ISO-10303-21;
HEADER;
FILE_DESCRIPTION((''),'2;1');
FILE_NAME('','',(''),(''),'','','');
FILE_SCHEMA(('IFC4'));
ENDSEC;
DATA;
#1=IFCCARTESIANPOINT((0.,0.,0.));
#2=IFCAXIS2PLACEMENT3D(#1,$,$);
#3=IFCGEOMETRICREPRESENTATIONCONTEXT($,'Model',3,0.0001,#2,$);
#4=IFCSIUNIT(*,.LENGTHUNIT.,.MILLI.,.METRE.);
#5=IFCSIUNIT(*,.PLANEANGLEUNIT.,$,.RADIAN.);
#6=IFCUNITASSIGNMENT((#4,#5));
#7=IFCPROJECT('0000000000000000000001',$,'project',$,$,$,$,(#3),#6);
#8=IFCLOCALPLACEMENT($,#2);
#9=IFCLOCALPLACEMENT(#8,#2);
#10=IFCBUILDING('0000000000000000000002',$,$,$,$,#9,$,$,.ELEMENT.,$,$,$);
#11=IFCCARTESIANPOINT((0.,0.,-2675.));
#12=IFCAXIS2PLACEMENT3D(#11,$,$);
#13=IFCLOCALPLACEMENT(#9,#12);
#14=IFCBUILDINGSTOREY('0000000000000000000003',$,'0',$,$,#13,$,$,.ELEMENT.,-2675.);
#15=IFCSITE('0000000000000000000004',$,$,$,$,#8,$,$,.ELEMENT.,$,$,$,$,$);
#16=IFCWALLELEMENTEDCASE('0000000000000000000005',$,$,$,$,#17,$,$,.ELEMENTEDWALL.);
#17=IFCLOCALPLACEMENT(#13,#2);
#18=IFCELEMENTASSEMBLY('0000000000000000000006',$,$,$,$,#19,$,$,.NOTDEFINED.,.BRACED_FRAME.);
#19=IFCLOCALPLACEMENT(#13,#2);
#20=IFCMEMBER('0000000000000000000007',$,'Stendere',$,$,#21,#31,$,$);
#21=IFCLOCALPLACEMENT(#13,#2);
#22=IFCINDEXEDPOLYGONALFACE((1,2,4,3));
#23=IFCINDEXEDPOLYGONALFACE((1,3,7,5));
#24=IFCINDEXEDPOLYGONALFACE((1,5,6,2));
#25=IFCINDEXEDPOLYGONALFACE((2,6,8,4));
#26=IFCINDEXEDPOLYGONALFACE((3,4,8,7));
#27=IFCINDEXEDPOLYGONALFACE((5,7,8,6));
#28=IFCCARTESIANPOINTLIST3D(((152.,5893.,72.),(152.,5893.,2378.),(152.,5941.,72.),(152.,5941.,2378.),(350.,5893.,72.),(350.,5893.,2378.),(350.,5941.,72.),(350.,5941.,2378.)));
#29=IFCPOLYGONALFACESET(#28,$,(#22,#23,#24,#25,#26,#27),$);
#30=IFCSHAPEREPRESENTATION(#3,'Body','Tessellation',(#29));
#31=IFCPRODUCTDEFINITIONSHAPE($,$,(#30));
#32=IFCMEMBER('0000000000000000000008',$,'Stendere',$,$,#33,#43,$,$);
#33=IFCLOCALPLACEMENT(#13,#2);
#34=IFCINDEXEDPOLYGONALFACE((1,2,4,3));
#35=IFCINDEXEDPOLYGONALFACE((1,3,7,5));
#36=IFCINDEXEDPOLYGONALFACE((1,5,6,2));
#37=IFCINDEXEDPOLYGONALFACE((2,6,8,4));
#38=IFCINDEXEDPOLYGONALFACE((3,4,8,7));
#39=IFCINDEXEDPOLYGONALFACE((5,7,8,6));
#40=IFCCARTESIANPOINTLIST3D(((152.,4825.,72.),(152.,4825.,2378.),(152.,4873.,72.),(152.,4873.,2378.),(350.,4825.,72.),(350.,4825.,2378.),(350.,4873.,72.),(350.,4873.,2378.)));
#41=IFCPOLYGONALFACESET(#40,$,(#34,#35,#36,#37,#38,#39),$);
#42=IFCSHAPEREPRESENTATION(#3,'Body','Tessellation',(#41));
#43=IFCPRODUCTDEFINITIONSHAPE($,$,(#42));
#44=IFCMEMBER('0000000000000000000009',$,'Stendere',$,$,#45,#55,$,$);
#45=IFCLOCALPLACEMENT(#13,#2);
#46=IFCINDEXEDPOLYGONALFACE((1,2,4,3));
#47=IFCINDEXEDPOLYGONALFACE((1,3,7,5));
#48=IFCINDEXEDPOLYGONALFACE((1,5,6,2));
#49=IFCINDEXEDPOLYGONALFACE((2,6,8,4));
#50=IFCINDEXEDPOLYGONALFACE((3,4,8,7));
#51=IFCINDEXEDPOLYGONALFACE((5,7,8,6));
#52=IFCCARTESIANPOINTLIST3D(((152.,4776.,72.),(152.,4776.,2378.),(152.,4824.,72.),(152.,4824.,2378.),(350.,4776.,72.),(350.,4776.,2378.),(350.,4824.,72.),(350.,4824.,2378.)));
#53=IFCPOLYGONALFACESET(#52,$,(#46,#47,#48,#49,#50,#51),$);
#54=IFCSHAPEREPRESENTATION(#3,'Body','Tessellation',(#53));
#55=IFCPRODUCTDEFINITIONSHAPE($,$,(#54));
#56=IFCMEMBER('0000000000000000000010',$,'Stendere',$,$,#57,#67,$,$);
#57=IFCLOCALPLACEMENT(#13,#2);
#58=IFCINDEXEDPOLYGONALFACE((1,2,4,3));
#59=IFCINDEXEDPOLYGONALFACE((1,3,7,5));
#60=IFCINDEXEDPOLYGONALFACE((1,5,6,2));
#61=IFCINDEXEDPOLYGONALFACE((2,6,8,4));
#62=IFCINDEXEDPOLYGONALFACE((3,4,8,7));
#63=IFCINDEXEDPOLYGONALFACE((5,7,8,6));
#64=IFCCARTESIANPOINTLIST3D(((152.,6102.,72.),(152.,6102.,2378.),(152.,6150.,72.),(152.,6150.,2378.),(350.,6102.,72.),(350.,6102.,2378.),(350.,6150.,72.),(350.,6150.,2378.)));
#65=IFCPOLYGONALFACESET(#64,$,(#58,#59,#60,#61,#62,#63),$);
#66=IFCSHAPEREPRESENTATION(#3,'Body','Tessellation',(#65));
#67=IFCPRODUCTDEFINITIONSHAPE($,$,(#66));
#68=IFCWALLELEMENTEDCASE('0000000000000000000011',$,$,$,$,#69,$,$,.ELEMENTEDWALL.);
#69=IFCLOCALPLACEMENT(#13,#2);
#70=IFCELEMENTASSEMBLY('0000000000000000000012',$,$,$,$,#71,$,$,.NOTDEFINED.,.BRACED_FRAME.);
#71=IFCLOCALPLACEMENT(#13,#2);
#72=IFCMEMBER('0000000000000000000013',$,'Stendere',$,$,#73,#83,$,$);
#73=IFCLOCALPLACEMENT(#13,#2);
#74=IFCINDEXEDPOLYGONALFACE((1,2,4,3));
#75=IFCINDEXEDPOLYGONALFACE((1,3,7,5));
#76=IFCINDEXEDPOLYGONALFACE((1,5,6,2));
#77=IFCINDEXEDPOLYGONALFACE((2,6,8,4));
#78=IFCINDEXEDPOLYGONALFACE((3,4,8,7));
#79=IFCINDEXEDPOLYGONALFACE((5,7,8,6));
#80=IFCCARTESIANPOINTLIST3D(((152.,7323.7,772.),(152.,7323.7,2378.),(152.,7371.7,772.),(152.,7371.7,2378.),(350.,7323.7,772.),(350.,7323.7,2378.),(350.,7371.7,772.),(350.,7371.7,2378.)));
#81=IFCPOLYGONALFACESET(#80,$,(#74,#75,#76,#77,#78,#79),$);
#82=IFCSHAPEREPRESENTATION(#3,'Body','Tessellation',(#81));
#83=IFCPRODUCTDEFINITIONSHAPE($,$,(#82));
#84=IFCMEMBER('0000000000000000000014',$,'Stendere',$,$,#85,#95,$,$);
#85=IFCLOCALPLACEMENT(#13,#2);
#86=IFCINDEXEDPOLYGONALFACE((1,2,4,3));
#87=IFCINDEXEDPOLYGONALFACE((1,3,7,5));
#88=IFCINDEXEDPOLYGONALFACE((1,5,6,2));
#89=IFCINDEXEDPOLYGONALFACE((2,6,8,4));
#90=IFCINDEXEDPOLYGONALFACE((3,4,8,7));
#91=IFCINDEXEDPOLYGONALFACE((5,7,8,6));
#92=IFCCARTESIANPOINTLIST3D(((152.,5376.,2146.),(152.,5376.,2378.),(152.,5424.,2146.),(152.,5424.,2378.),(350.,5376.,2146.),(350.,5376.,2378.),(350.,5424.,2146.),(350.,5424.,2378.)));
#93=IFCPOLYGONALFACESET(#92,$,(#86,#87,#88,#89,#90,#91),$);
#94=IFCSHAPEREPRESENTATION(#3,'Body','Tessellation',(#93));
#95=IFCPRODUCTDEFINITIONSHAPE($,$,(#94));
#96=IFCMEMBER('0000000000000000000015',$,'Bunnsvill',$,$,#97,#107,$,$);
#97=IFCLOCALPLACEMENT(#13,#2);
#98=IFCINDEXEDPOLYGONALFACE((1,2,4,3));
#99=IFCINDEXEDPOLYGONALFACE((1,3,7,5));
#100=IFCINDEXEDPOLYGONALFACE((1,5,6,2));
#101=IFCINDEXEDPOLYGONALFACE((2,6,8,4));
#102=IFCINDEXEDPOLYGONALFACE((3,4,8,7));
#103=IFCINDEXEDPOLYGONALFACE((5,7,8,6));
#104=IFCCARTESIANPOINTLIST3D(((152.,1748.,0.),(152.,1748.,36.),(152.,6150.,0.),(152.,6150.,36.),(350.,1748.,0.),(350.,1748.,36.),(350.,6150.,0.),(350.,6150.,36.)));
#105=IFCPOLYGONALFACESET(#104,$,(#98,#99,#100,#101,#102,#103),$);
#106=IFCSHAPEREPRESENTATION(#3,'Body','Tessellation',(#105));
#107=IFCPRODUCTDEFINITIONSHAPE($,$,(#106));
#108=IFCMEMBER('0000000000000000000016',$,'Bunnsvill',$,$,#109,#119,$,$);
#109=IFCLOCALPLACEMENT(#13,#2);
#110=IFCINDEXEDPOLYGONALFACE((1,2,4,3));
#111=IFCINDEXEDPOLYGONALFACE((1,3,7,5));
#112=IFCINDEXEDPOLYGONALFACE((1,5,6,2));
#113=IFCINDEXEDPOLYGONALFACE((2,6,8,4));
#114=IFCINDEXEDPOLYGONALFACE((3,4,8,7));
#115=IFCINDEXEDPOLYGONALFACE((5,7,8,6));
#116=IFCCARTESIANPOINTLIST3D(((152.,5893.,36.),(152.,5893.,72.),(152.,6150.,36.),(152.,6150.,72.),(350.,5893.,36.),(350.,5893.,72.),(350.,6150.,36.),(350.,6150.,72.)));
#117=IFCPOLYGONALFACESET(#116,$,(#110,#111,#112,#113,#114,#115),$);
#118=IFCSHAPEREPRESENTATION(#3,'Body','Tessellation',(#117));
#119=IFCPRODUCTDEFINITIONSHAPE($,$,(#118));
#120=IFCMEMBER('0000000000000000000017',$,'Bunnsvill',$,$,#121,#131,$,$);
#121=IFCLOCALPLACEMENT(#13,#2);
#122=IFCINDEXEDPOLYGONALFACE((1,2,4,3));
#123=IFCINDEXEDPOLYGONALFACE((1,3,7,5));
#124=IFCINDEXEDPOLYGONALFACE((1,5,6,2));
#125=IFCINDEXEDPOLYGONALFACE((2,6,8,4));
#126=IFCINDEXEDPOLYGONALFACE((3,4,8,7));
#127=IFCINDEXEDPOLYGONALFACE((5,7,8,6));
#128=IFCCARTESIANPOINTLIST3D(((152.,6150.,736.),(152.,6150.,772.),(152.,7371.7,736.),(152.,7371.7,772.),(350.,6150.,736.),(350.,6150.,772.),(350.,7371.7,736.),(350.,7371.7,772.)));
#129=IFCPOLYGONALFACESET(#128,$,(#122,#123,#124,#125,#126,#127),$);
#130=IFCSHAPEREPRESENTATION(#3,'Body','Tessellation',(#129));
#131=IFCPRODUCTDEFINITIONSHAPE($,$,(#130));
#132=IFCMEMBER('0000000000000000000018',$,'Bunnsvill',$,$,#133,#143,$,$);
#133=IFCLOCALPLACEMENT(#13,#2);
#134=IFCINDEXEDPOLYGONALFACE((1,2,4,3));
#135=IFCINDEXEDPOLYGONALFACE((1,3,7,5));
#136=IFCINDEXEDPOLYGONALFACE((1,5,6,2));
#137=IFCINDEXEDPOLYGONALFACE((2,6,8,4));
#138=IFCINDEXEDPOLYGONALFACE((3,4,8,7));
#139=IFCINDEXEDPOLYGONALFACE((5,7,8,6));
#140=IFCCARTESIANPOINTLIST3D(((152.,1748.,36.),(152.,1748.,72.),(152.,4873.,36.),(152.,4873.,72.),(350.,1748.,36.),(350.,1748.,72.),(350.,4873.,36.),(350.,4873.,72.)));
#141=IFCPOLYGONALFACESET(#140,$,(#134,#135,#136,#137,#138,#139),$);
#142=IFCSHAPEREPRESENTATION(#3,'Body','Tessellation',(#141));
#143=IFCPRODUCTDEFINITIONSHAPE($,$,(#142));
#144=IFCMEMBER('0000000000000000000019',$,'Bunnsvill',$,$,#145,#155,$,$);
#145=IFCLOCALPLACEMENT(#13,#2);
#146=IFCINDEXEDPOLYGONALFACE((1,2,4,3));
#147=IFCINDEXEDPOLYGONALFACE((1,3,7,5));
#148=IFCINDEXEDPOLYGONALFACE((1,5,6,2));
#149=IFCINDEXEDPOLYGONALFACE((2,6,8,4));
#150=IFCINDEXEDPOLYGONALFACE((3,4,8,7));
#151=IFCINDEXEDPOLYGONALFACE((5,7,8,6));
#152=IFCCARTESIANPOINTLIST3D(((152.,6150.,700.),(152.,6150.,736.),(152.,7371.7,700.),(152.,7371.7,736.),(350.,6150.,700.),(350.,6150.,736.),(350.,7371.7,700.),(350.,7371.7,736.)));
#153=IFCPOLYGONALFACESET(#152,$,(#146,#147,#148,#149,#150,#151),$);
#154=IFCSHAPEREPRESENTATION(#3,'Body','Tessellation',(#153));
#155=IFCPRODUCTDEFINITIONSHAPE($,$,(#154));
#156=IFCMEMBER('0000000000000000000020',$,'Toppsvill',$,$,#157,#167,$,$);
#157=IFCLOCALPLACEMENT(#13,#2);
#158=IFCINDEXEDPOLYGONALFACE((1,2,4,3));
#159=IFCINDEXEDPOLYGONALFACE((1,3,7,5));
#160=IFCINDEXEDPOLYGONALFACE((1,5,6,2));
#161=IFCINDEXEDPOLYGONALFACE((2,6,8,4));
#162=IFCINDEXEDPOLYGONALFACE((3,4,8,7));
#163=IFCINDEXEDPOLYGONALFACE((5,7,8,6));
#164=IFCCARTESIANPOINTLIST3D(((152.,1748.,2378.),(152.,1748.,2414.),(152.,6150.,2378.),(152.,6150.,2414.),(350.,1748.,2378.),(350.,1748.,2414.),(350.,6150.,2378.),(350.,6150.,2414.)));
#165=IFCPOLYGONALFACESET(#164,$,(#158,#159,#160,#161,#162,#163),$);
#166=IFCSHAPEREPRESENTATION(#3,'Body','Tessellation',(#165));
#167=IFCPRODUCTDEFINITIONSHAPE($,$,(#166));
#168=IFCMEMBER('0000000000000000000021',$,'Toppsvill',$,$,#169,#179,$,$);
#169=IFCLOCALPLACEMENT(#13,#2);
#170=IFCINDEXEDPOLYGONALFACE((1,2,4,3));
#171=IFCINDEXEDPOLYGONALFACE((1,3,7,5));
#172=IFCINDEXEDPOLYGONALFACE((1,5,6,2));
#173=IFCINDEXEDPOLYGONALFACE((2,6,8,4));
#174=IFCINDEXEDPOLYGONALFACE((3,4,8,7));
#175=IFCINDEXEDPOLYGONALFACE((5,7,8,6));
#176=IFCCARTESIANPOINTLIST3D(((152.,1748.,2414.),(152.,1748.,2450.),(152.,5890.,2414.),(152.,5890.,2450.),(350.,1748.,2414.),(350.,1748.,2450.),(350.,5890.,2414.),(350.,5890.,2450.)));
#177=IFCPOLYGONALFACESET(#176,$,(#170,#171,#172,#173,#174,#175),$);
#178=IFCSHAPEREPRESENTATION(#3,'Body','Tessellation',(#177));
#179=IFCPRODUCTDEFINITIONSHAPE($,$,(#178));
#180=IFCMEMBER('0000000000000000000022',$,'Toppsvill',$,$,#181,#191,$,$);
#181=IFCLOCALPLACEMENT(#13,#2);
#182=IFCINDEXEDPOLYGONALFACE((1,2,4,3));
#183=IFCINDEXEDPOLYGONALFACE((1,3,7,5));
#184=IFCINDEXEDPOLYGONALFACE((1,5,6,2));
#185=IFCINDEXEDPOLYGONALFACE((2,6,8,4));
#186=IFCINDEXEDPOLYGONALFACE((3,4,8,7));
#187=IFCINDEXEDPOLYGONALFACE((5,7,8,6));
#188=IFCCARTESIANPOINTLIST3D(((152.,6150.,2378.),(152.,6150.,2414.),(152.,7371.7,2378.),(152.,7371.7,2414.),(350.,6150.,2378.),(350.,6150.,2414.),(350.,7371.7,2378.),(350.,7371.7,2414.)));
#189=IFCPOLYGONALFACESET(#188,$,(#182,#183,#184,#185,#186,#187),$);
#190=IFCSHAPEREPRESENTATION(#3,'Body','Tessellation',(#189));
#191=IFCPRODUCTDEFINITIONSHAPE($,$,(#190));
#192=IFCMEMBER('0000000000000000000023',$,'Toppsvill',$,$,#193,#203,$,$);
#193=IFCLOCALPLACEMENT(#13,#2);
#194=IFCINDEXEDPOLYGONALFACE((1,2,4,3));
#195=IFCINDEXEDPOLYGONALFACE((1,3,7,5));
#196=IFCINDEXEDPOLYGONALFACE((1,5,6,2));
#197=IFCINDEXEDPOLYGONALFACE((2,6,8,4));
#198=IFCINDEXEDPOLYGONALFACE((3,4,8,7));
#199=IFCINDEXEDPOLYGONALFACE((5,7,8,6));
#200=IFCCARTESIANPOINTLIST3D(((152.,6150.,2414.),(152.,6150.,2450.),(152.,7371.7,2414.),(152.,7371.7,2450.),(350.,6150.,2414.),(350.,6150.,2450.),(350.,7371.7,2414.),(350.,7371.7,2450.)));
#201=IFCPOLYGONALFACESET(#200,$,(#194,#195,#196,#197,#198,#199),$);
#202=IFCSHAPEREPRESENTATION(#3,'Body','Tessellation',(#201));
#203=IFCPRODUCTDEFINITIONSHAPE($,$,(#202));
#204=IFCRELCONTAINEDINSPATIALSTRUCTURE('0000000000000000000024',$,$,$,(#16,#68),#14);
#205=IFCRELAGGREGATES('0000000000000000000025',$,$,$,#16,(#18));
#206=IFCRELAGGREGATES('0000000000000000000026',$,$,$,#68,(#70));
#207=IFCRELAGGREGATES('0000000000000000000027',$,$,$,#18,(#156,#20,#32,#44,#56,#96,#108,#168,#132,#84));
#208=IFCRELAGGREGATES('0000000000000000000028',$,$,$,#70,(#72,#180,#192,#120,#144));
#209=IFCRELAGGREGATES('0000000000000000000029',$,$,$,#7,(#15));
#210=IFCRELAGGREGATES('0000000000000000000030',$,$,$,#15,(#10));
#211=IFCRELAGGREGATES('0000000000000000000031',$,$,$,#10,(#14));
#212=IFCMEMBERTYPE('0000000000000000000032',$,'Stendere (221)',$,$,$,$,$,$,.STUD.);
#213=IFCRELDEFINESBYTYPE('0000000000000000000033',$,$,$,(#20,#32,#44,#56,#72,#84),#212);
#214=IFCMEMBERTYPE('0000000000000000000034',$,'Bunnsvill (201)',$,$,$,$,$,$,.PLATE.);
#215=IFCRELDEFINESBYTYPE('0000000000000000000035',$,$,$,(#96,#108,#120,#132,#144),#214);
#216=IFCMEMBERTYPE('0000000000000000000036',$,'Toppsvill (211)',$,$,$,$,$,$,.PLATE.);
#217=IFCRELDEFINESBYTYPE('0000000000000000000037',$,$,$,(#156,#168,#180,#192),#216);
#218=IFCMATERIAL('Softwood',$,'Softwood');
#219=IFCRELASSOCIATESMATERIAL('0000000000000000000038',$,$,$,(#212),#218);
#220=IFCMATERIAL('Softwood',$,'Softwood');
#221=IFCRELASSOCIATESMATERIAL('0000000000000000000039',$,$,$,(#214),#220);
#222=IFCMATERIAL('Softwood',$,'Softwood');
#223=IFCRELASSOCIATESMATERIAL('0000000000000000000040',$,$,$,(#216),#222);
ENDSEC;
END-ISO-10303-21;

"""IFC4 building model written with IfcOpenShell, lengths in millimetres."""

from ifc_helpers import new_model, si_unit, frame, origin, place, context, project, spatial, rectangle, extrude, clip, halfspace, material, material_profile, profile_set, type_object, element, aggregate, save


model = new_model("IFC4")

# Units and contexts
model_context = context("Model", 3, precision=0.0001, world=origin())
ifc_project = project(units=[si_unit("LENGTHUNIT", "METRE", prefix="MILLI"), si_unit("PLANEANGLEUNIT", "RADIAN")], contexts=[model_context])

# Site, building, storey
site_placement = place(None, origin())
site = spatial("IfcSite", under=ifc_project, at=site_placement, CompositionType="ELEMENT")
building_placement = place(site_placement, origin())
building = spatial("IfcBuilding", under=site, at=building_placement, CompositionType="ELEMENT")
storey_placement = place(building_placement, frame((0.0, 0.0, -2675.0)))
storey = spatial("IfcBuildingStorey", under=building, at=storey_placement, Name="0", CompositionType="ELEMENT", Elevation=-2675.0)

# Shared definitions
ifc_material_1 = material(Name="Softwood", Category="Softwood")
ifc_material_profile_1 = material_profile(ifc_material_1, rectangle(XDim=48.0, YDim=198.0), Name="Stendere (221)")
ifc_profile_set_1 = profile_set([ifc_material_profile_1])
member_type_1 = type_object("IfcMemberType", Name="Stendere (221)", PredefinedType="STUD", material=ifc_profile_set_1)

# Wall, element assembly, member
wall_1_placement = place(storey_placement, frame((350.0, 6150.0, 0.0), z_axis=(-1.0, 0.0, 0.0), x_axis=(0.0, -1.0, 0.0)))
wall_1 = element("IfcWallElementedCase", 1, at=wall_1_placement, inside=storey, PredefinedType="ELEMENTEDWALL")
assembly_1_placement = place(wall_1_placement, origin())
assembly_1 = element("IfcElementAssembly", 2, at=assembly_1_placement, AssemblyPlace="NOTDEFINED", PredefinedType="BRACED_FRAME")
aggregate(wall_1, [assembly_1])
member_1_placement = place(assembly_1_placement, frame((233.0, 72.0, 0.0), z_axis=(0.0, 1.0, 0.0), x_axis=(-1.0, 0.0, 0.0)))
member_1 = element("IfcMember", 3, at=member_1_placement, type_object=member_type_1, Name="Stendere", context=model_context, shape_type="SweptSolid", body=[
    extrude(rectangle(XDim=48.0, YDim=198.0), frame((0.0, 99.0, 0.0)), (0.0, 0.0, 1.0), 2306.0),
])

# Members
member_2_placement = place(assembly_1_placement, frame((1301.0, 72.0, 0.0), z_axis=(0.0, 1.0, 0.0), x_axis=(-1.0, 0.0, 0.0)))
member_2 = element("IfcMember", 4, at=member_2_placement, type_object=member_type_1, Name="Stendere", context=model_context, shape_type="SweptSolid", body=[
    extrude(rectangle(XDim=48.0, YDim=198.0), frame((0.0, 99.0, 0.0)), (0.0, 0.0, 1.0), 2306.0),
])
member_3_placement = place(assembly_1_placement, frame((1350.0, 72.0, 0.0), z_axis=(0.0, 1.0, 0.0), x_axis=(-1.0, 0.0, 0.0)))
member_3 = element("IfcMember", 5, at=member_3_placement, type_object=member_type_1, Name="Stendere", context=model_context, shape_type="SweptSolid", body=[
    extrude(rectangle(XDim=48.0, YDim=198.0), frame((0.0, 99.0, 0.0)), (0.0, 0.0, 1.0), 2306.0),
])
member_4_placement = place(assembly_1_placement, frame((24.0, 72.0, 0.0), z_axis=(0.0, 1.0, 0.0), x_axis=(-1.0, 0.0, 0.0)))
member_4 = element("IfcMember", 6, at=member_4_placement, type_object=member_type_1, Name="Stendere", context=model_context, shape_type="SweptSolid", body=[
    extrude(rectangle(XDim=48.0, YDim=198.0), frame((0.0, 99.0, 0.0)), (0.0, 0.0, 1.0), 2306.0),
])

# Wall, element assembly, member
wall_2_placement = place(storey_placement, frame((350.0, 7371.7, 700.0), z_axis=(-1.0, 0.0, 0.0), x_axis=(0.0, -1.0, 0.0)))
wall_2 = element("IfcWallElementedCase", 7, at=wall_2_placement, inside=storey, PredefinedType="ELEMENTEDWALL")
assembly_2_placement = place(wall_2_placement, origin())
assembly_2 = element("IfcElementAssembly", 8, at=assembly_2_placement, AssemblyPlace="NOTDEFINED", PredefinedType="BRACED_FRAME")
aggregate(wall_2, [assembly_2])
member_5_placement = place(assembly_2_placement, frame((24.0, 72.0, 0.0), z_axis=(0.0, 1.0, 0.0), x_axis=(-1.0, 0.0, 0.0)))
member_5 = element("IfcMember", 9, at=member_5_placement, type_object=member_type_1, Name="Stendere", context=model_context, shape_type="SweptSolid", body=[
    extrude(rectangle(XDim=48.0, YDim=198.0), frame((0.0, 99.0, 0.0)), (0.0, 0.0, 1.0), 1606.0),
])

# Members
member_6_placement = place(assembly_1_placement, frame((750.0, 2146.0, 0.0), z_axis=(0.0, 1.0, 0.0), x_axis=(-1.0, 0.0, 0.0)))
member_6 = element("IfcMember", 10, at=member_6_placement, type_object=member_type_1, Name="Stendere", context=model_context, shape_type="SweptSolid", body=[
    extrude(rectangle(XDim=48.0, YDim=198.0), frame((0.0, 99.0, 0.0)), (0.0, 0.0, 1.0), 232.0),
])
ifc_material_2 = material(Name="Softwood", Category="Softwood")
ifc_material_profile_2 = material_profile(ifc_material_2, rectangle(XDim=36.0, YDim=198.0), Name="Bunnsvill (201)")
ifc_profile_set_2 = profile_set([ifc_material_profile_2])
member_type_2 = type_object("IfcMemberType", Name="Bunnsvill (201)", PredefinedType="PLATE", material=ifc_profile_set_2)
member_7_placement = place(assembly_1_placement, frame((0.0, 18.0, 0.0), z_axis=(1.0, 0.0, 0.0), x_axis=(0.0, 1.0, 0.0)))
member_7 = element("IfcMember", 11, at=member_7_placement, type_object=member_type_2, Name="Bunnsvill", context=model_context, shape_type="SweptSolid", body=[
    extrude(rectangle(XDim=36.0, YDim=198.0), frame((0.0, 99.0, 0.0)), (0.0, 0.0, 1.0), 4402.0),
])
member_8_placement = place(assembly_1_placement, frame((0.0, 54.0, 0.0), z_axis=(1.0, 0.0, 0.0), x_axis=(0.0, 1.0, 0.0)))
member_8 = element("IfcMember", 12, at=member_8_placement, type_object=member_type_2, Name="Bunnsvill", context=model_context, shape_type="SweptSolid", body=[
    extrude(rectangle(XDim=36.0, YDim=198.0), frame((0.0, 99.0, 0.0)), (0.0, 0.0, 1.0), 257.0),
])
member_9_placement = place(assembly_2_placement, frame((0.0, 54.0, 0.0), z_axis=(1.0, 0.0, 0.0), x_axis=(0.0, 1.0, 0.0)))
member_9 = element("IfcMember", 13, at=member_9_placement, type_object=member_type_2, Name="Bunnsvill", context=model_context, shape_type="SweptSolid", body=[
    extrude(rectangle(XDim=36.0, YDim=198.0), frame((0.0, 99.0, 0.0)), (0.0, 0.0, 1.0), 1221.7),
])
member_10_placement = place(assembly_1_placement, frame((1277.0, 54.0, 0.0), z_axis=(1.0, 0.0, 0.0), x_axis=(0.0, 1.0, 0.0)))
member_10 = element("IfcMember", 14, at=member_10_placement, type_object=member_type_2, Name="Bunnsvill", context=model_context, shape_type="SweptSolid", body=[
    extrude(rectangle(XDim=36.0, YDim=198.0), frame((0.0, 99.0, 0.0)), (0.0, 0.0, 1.0), 3125.0),
])
member_11_placement = place(assembly_2_placement, frame((0.0, 18.0, 0.0), z_axis=(1.0, 0.0, 0.0), x_axis=(0.0, 1.0, 0.0)))
member_11 = element("IfcMember", 15, at=member_11_placement, type_object=member_type_2, Name="Bunnsvill", context=model_context, shape_type="SweptSolid", body=[
    extrude(rectangle(XDim=36.0, YDim=198.0), frame((0.0, 99.0, 0.0)), (0.0, 0.0, 1.0), 1221.7),
])
ifc_material_3 = material(Name="Softwood", Category="Softwood")
ifc_material_profile_3 = material_profile(ifc_material_3, rectangle(XDim=36.0, YDim=198.0), Name="Toppsvill (211)")
ifc_profile_set_3 = profile_set([ifc_material_profile_3])
member_type_3 = type_object("IfcMemberType", Name="Toppsvill (211)", PredefinedType="PLATE", material=ifc_profile_set_3)
member_12_placement = place(assembly_1_placement, frame((0.0, 2396.0, 0.0), z_axis=(1.0, 0.0, 0.0), x_axis=(0.0, 1.0, 0.0)))
member_12 = element("IfcMember", 16, at=member_12_placement, type_object=member_type_3, Name="Toppsvill", context=model_context, shape_type="SweptSolid", body=[
    extrude(rectangle(XDim=36.0, YDim=198.0), frame((0.0, 99.0, 0.0)), (0.0, 0.0, 1.0), 4402.0),
])
member_13_placement = place(assembly_1_placement, frame((260.0, 2432.0, 0.0), z_axis=(1.0, 0.0, 0.0), x_axis=(0.0, 1.0, 0.0)))
member_13 = element("IfcMember", 17, at=member_13_placement, type_object=member_type_3, Name="Toppsvill", context=model_context, shape_type="SweptSolid", body=[
    extrude(rectangle(XDim=36.0, YDim=198.0), frame((0.0, 99.0, 0.0)), (0.0, 0.0, 1.0), 4142.0),
])
member_14_placement = place(assembly_2_placement, frame((0.0, 1696.0, 0.0), z_axis=(1.0, 0.0, 0.0), x_axis=(0.0, 1.0, 0.0)))
member_14 = element("IfcMember", 18, at=member_14_placement, type_object=member_type_3, Name="Toppsvill", context=model_context, shape_type="SweptSolid", body=[
    extrude(rectangle(XDim=36.0, YDim=198.0), frame((0.0, 99.0, 0.0)), (0.0, 0.0, 1.0), 1221.7),
])
member_15_placement = place(assembly_2_placement, frame((0.0, 1732.0, 0.0), z_axis=(1.0, 0.0, 0.0), x_axis=(0.0, 1.0, 0.0)))
member_15 = element("IfcMember", 19, at=member_15_placement, type_object=member_type_3, Name="Toppsvill", context=model_context, shape_type="Clipping", body=[
    clip(extrude(rectangle(XDim=36.0, YDim=198.0), frame((0.0, 99.0, 0.0)), (0.0, 0.0, 1.0), 1221.7), halfspace(frame((0.0, 99.0, 0.0)), True)),
])
aggregate(assembly_1, [member_12, member_1, member_2, member_3, member_4, member_7, member_8, member_13, member_10, member_6])

aggregate(assembly_2, [member_5, member_14, member_15, member_9, member_11])

save(model, "model.ifc")
